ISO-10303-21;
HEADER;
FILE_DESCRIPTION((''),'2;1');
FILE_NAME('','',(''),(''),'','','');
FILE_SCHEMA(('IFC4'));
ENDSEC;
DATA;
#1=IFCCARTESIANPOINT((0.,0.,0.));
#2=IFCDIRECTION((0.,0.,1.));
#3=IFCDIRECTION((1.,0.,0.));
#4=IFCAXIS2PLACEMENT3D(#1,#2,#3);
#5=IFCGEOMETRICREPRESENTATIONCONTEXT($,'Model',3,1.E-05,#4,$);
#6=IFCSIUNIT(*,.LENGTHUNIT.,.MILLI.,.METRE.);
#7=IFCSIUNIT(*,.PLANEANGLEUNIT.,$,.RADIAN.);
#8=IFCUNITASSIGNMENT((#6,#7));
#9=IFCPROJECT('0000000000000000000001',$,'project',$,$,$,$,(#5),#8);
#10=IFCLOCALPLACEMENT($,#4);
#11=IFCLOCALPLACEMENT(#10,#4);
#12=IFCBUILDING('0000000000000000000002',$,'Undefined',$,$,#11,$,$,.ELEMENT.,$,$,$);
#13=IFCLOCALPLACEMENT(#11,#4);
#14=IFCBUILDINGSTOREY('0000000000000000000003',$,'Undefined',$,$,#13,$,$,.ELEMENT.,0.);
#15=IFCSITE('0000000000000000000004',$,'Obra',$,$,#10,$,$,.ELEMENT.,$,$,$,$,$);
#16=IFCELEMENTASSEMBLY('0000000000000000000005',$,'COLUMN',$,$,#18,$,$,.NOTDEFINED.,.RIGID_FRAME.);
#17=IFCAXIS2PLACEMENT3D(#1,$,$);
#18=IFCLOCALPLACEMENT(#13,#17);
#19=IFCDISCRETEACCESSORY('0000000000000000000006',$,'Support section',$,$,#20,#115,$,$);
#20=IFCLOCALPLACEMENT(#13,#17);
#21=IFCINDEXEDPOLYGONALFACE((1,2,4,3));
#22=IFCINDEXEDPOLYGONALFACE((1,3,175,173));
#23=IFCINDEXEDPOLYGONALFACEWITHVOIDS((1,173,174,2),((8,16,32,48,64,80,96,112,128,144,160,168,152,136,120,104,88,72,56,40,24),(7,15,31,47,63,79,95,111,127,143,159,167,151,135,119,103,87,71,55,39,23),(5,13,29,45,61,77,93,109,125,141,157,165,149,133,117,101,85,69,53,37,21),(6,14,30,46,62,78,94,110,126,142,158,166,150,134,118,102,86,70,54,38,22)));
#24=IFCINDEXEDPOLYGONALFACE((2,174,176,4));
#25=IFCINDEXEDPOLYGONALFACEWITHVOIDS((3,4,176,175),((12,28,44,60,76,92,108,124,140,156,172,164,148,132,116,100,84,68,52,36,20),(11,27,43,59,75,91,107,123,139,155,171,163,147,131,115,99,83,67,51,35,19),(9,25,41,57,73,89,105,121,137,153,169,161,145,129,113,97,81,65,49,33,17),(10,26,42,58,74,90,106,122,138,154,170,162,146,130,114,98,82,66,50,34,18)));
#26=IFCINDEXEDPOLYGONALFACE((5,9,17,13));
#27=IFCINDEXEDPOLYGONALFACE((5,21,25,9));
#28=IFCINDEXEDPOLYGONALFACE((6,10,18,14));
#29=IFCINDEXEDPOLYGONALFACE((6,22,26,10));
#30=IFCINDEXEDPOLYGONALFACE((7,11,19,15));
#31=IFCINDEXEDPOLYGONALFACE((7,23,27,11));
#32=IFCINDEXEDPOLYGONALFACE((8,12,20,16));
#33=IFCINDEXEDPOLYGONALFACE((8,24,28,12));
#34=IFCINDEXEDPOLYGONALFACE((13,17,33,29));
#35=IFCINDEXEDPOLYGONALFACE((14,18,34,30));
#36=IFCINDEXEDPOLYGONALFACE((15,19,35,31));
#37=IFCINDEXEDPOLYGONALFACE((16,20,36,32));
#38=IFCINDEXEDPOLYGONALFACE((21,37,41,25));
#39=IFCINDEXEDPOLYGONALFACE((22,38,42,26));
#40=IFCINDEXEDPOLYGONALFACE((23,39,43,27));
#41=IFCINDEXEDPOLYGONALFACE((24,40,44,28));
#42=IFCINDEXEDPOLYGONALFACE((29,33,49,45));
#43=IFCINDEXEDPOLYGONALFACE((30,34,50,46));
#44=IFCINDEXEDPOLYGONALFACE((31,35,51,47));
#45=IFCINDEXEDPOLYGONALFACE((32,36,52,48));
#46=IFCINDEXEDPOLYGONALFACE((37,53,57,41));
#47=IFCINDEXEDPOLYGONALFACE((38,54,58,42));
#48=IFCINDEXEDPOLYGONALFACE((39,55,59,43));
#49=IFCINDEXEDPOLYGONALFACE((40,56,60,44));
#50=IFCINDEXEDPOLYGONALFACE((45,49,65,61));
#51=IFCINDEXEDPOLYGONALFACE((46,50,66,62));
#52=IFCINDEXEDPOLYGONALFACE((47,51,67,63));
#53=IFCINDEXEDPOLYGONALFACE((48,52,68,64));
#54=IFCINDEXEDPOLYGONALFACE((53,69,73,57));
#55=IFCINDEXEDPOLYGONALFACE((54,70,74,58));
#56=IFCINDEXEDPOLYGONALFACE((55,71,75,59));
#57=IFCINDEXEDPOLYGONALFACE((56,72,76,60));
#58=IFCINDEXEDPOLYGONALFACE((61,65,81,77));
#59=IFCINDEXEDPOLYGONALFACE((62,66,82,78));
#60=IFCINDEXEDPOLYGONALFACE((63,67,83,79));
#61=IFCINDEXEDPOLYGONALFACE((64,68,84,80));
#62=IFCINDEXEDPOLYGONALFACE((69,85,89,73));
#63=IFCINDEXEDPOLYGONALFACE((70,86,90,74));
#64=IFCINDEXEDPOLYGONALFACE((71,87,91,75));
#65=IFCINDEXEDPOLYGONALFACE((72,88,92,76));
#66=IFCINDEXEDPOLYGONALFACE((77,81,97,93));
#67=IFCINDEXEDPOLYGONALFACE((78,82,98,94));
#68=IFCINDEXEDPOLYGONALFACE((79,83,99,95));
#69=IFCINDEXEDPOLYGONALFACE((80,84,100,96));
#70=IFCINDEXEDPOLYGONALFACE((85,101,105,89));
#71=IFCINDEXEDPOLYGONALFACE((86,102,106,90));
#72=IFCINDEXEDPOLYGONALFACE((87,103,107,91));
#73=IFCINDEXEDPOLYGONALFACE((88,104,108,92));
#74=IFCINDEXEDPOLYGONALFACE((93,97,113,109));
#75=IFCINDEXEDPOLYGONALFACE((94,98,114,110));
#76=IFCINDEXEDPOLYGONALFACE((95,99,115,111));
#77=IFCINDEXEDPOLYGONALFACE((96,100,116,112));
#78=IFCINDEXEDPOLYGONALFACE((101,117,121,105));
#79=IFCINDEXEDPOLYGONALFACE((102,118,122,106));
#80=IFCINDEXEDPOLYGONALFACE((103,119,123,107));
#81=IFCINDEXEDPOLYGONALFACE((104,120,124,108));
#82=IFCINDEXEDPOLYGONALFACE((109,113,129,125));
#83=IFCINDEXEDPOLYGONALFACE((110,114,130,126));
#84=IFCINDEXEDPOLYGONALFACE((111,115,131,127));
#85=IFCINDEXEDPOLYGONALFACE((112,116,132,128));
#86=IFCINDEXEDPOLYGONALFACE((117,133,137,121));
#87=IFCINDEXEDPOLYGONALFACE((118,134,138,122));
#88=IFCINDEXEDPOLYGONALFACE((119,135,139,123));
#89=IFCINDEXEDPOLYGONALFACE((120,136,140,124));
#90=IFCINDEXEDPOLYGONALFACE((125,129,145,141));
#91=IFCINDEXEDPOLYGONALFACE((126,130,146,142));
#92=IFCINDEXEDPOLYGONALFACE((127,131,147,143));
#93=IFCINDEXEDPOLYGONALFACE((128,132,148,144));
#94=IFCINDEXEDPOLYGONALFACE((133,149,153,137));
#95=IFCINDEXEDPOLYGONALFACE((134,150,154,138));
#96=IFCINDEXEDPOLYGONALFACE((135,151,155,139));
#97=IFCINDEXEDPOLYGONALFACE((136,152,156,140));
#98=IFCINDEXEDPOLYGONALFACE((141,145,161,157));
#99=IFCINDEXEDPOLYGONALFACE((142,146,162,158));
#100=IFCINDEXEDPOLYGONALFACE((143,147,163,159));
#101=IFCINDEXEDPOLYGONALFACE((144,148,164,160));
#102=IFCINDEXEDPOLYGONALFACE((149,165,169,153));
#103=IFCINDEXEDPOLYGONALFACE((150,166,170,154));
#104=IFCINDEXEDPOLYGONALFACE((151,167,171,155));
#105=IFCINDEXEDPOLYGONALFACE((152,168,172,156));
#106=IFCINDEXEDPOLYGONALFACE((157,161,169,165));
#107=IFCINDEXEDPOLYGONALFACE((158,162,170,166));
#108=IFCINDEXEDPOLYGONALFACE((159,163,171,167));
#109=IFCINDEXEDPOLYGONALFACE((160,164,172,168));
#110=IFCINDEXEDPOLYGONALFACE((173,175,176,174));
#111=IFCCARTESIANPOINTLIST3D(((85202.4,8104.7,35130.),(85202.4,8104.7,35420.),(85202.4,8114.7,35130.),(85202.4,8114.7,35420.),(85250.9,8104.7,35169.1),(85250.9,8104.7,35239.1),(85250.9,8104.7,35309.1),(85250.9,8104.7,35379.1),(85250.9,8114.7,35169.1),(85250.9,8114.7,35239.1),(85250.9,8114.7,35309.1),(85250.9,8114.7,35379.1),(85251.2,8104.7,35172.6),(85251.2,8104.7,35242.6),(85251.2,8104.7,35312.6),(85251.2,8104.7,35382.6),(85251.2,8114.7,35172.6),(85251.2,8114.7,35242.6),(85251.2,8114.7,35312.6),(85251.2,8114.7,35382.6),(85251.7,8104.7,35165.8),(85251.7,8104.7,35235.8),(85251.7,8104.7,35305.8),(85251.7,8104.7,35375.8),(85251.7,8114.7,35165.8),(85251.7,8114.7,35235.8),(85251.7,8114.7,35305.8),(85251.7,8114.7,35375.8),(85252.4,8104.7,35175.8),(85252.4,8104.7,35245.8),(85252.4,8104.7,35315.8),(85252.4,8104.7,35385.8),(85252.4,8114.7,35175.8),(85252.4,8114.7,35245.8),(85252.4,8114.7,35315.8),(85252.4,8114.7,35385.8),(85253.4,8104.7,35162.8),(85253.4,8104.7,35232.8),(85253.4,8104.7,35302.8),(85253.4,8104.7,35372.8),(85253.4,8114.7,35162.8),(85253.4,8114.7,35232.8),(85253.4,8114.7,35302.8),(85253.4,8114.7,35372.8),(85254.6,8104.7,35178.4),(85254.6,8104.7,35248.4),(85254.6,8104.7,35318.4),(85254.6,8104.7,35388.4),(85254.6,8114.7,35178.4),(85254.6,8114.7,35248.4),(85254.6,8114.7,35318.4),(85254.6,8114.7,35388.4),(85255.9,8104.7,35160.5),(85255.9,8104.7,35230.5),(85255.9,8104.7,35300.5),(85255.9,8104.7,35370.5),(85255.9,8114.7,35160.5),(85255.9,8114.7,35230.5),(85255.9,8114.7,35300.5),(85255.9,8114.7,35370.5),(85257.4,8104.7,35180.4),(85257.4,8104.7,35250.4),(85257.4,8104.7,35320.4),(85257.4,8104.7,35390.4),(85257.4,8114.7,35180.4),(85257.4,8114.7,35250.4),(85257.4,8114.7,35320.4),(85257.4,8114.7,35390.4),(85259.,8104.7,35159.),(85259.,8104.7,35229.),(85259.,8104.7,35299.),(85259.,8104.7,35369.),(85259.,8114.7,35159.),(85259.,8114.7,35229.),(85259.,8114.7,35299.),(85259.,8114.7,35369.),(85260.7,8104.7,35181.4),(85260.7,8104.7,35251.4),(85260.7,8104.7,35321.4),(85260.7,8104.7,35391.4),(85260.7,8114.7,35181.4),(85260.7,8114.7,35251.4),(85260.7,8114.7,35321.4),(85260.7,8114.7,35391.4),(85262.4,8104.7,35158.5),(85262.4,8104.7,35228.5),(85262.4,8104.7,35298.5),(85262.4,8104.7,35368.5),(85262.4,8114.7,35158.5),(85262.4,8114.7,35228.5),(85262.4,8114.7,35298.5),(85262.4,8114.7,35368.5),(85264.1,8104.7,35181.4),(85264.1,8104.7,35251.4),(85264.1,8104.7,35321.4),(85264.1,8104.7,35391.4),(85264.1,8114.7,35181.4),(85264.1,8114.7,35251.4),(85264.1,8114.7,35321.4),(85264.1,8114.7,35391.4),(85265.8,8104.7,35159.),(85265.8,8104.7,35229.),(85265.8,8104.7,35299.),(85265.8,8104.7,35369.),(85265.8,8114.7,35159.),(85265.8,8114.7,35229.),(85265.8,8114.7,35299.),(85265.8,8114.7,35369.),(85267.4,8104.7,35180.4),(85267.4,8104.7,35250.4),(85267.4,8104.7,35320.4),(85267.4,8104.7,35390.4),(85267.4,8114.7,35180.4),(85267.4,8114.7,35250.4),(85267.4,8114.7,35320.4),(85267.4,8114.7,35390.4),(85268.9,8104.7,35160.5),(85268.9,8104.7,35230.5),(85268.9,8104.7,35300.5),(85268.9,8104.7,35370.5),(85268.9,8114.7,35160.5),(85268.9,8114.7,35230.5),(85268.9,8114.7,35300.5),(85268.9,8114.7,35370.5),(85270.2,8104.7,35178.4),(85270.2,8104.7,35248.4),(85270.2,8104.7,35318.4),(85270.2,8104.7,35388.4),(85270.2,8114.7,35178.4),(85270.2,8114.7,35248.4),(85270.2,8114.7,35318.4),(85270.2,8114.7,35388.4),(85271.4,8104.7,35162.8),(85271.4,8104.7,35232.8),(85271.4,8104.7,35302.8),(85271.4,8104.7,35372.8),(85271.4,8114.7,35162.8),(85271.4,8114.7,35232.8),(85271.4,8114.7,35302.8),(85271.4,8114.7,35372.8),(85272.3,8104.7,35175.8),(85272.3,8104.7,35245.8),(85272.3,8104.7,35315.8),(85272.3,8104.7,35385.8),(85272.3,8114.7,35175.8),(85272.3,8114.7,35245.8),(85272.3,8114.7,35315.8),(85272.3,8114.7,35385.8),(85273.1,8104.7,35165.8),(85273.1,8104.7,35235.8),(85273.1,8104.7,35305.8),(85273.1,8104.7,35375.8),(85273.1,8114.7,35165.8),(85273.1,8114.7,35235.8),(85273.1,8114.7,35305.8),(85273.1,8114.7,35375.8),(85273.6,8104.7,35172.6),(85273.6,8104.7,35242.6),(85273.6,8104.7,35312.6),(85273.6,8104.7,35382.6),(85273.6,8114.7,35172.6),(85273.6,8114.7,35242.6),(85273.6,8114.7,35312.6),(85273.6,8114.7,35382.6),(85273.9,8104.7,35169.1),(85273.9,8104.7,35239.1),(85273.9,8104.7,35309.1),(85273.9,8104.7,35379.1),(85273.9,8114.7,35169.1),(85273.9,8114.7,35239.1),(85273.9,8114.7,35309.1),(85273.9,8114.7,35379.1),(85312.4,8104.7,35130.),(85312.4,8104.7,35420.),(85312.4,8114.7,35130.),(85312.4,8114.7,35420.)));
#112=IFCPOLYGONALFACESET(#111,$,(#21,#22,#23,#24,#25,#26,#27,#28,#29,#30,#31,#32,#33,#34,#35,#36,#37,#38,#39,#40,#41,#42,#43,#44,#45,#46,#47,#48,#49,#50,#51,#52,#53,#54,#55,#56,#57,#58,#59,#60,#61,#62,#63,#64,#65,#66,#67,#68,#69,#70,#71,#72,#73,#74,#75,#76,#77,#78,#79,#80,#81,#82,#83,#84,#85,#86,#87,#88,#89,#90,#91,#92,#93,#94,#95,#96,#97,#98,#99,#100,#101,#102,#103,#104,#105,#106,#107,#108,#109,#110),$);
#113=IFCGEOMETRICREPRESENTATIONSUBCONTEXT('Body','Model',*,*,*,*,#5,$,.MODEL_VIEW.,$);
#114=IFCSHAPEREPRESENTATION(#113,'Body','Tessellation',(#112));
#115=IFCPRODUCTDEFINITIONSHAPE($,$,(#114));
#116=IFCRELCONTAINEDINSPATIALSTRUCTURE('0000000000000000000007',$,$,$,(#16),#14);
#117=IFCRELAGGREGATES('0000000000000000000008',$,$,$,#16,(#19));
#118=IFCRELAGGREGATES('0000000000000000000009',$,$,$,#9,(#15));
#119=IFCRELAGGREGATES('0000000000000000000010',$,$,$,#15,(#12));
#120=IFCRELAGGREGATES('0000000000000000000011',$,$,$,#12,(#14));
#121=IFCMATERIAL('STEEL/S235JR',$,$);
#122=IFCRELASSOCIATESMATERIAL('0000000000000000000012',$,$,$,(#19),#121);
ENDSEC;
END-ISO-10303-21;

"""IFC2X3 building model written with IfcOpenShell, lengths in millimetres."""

from ifc_helpers import new_model, si_unit, frame, origin_with_axes, origin_2d_with_axis, place, context, subcontext, project, spatial, rectangle, circle, extrude, source, transform, mapped, material, element, aggregate, save


model = new_model("IFC2X3")

# Units and contexts
model_context = context("Model", 3, precision=1e-05, world=origin_with_axes())
body_context = subcontext(model_context, "Body", "Model", "MODEL_VIEW")
ifc_project = project(units=[si_unit("LENGTHUNIT", "METRE", prefix="MILLI"), si_unit("PLANEANGLEUNIT", "RADIAN")], contexts=[model_context])

# Site, building, storey
site_placement = place(None, origin_with_axes())
site = spatial("IfcSite", under=ifc_project, at=site_placement, Name="Obra", CompositionType="ELEMENT")
building_placement = place(site_placement, origin_with_axes())
building = spatial("IfcBuilding", under=site, at=building_placement, Name="Undefined", CompositionType="ELEMENT")
storey_placement = place(building_placement, origin_with_axes())
storey = spatial("IfcBuildingStorey", under=building, at=storey_placement, Name="Undefined", CompositionType="ELEMENT", Elevation=0.0)

# Element assembly
assembly_1_placement = place(storey_placement, origin_with_axes())
assembly_1 = element("IfcElementAssembly", 1, at=assembly_1_placement, inside=storey, Name="COLUMN", AssemblyPlace="NOTDEFINED", PredefinedType="RIGID_FRAME")
ifc_material_1 = material(Name="STEEL/S235JR")

# Discrete accessory, opening
discrete_accessory_1_placement = place(assembly_1_placement, frame((85257.4, 8109.7, 35130.0), z_axis=(0.0, 0.0, 1.0), x_axis=(-1.0, 0.0, 0.0)))
discrete_accessory_1 = element("IfcDiscreteAccessory", 2, at=discrete_accessory_1_placement, material=ifc_material_1, Name="Support section", context=body_context, shape_type="SweptSolid", body=[
    extrude(rectangle(XDim=10.0, YDim=110.0, at=origin_2d_with_axis()), frame((0.0, 0.0, 290.0), z_axis=(0.0, 0.0, -1.0), x_axis=(0.0, 1.0, 0.0)), (0.0, 0.0, 1.0), 290.0),
])
shared_shape_1 = source(origin_with_axes(), body_context, "Body", "SweptSolid", [
    extrude(circle(Radius=11.5, at=origin_2d_with_axis()), frame((0.0, -15.6, 0.0), z_axis=(0.0, 1.0, 0.0), x_axis=(1.0, 0.0, 0.0)), (0.0, 0.0, 1.0), 10.2),
])
opening_1_placement = place(assembly_1_placement, frame((85212.4, 8120.2, 35470.0), z_axis=(1.0, 0.0, 0.0), x_axis=(0.0, 0.0, -1.0)))
element("IfcOpeningElement", 3, at=opening_1_placement, cuts=discrete_accessory_1, ObjectType="Opening", context=body_context, shape_type="MappedRepresentation", body=[
    mapped(shared_shape_1, transform((90.0, 0.0, 50.0))),
    mapped(shared_shape_1, transform((160.0, 0.0, 50.0))),
    mapped(shared_shape_1, transform((230.0, 0.0, 50.0))),
    mapped(shared_shape_1, transform((300.0, 0.0, 50.0))),
])
aggregate(assembly_1, [discrete_accessory_1])

save(model, "model.ifc")
